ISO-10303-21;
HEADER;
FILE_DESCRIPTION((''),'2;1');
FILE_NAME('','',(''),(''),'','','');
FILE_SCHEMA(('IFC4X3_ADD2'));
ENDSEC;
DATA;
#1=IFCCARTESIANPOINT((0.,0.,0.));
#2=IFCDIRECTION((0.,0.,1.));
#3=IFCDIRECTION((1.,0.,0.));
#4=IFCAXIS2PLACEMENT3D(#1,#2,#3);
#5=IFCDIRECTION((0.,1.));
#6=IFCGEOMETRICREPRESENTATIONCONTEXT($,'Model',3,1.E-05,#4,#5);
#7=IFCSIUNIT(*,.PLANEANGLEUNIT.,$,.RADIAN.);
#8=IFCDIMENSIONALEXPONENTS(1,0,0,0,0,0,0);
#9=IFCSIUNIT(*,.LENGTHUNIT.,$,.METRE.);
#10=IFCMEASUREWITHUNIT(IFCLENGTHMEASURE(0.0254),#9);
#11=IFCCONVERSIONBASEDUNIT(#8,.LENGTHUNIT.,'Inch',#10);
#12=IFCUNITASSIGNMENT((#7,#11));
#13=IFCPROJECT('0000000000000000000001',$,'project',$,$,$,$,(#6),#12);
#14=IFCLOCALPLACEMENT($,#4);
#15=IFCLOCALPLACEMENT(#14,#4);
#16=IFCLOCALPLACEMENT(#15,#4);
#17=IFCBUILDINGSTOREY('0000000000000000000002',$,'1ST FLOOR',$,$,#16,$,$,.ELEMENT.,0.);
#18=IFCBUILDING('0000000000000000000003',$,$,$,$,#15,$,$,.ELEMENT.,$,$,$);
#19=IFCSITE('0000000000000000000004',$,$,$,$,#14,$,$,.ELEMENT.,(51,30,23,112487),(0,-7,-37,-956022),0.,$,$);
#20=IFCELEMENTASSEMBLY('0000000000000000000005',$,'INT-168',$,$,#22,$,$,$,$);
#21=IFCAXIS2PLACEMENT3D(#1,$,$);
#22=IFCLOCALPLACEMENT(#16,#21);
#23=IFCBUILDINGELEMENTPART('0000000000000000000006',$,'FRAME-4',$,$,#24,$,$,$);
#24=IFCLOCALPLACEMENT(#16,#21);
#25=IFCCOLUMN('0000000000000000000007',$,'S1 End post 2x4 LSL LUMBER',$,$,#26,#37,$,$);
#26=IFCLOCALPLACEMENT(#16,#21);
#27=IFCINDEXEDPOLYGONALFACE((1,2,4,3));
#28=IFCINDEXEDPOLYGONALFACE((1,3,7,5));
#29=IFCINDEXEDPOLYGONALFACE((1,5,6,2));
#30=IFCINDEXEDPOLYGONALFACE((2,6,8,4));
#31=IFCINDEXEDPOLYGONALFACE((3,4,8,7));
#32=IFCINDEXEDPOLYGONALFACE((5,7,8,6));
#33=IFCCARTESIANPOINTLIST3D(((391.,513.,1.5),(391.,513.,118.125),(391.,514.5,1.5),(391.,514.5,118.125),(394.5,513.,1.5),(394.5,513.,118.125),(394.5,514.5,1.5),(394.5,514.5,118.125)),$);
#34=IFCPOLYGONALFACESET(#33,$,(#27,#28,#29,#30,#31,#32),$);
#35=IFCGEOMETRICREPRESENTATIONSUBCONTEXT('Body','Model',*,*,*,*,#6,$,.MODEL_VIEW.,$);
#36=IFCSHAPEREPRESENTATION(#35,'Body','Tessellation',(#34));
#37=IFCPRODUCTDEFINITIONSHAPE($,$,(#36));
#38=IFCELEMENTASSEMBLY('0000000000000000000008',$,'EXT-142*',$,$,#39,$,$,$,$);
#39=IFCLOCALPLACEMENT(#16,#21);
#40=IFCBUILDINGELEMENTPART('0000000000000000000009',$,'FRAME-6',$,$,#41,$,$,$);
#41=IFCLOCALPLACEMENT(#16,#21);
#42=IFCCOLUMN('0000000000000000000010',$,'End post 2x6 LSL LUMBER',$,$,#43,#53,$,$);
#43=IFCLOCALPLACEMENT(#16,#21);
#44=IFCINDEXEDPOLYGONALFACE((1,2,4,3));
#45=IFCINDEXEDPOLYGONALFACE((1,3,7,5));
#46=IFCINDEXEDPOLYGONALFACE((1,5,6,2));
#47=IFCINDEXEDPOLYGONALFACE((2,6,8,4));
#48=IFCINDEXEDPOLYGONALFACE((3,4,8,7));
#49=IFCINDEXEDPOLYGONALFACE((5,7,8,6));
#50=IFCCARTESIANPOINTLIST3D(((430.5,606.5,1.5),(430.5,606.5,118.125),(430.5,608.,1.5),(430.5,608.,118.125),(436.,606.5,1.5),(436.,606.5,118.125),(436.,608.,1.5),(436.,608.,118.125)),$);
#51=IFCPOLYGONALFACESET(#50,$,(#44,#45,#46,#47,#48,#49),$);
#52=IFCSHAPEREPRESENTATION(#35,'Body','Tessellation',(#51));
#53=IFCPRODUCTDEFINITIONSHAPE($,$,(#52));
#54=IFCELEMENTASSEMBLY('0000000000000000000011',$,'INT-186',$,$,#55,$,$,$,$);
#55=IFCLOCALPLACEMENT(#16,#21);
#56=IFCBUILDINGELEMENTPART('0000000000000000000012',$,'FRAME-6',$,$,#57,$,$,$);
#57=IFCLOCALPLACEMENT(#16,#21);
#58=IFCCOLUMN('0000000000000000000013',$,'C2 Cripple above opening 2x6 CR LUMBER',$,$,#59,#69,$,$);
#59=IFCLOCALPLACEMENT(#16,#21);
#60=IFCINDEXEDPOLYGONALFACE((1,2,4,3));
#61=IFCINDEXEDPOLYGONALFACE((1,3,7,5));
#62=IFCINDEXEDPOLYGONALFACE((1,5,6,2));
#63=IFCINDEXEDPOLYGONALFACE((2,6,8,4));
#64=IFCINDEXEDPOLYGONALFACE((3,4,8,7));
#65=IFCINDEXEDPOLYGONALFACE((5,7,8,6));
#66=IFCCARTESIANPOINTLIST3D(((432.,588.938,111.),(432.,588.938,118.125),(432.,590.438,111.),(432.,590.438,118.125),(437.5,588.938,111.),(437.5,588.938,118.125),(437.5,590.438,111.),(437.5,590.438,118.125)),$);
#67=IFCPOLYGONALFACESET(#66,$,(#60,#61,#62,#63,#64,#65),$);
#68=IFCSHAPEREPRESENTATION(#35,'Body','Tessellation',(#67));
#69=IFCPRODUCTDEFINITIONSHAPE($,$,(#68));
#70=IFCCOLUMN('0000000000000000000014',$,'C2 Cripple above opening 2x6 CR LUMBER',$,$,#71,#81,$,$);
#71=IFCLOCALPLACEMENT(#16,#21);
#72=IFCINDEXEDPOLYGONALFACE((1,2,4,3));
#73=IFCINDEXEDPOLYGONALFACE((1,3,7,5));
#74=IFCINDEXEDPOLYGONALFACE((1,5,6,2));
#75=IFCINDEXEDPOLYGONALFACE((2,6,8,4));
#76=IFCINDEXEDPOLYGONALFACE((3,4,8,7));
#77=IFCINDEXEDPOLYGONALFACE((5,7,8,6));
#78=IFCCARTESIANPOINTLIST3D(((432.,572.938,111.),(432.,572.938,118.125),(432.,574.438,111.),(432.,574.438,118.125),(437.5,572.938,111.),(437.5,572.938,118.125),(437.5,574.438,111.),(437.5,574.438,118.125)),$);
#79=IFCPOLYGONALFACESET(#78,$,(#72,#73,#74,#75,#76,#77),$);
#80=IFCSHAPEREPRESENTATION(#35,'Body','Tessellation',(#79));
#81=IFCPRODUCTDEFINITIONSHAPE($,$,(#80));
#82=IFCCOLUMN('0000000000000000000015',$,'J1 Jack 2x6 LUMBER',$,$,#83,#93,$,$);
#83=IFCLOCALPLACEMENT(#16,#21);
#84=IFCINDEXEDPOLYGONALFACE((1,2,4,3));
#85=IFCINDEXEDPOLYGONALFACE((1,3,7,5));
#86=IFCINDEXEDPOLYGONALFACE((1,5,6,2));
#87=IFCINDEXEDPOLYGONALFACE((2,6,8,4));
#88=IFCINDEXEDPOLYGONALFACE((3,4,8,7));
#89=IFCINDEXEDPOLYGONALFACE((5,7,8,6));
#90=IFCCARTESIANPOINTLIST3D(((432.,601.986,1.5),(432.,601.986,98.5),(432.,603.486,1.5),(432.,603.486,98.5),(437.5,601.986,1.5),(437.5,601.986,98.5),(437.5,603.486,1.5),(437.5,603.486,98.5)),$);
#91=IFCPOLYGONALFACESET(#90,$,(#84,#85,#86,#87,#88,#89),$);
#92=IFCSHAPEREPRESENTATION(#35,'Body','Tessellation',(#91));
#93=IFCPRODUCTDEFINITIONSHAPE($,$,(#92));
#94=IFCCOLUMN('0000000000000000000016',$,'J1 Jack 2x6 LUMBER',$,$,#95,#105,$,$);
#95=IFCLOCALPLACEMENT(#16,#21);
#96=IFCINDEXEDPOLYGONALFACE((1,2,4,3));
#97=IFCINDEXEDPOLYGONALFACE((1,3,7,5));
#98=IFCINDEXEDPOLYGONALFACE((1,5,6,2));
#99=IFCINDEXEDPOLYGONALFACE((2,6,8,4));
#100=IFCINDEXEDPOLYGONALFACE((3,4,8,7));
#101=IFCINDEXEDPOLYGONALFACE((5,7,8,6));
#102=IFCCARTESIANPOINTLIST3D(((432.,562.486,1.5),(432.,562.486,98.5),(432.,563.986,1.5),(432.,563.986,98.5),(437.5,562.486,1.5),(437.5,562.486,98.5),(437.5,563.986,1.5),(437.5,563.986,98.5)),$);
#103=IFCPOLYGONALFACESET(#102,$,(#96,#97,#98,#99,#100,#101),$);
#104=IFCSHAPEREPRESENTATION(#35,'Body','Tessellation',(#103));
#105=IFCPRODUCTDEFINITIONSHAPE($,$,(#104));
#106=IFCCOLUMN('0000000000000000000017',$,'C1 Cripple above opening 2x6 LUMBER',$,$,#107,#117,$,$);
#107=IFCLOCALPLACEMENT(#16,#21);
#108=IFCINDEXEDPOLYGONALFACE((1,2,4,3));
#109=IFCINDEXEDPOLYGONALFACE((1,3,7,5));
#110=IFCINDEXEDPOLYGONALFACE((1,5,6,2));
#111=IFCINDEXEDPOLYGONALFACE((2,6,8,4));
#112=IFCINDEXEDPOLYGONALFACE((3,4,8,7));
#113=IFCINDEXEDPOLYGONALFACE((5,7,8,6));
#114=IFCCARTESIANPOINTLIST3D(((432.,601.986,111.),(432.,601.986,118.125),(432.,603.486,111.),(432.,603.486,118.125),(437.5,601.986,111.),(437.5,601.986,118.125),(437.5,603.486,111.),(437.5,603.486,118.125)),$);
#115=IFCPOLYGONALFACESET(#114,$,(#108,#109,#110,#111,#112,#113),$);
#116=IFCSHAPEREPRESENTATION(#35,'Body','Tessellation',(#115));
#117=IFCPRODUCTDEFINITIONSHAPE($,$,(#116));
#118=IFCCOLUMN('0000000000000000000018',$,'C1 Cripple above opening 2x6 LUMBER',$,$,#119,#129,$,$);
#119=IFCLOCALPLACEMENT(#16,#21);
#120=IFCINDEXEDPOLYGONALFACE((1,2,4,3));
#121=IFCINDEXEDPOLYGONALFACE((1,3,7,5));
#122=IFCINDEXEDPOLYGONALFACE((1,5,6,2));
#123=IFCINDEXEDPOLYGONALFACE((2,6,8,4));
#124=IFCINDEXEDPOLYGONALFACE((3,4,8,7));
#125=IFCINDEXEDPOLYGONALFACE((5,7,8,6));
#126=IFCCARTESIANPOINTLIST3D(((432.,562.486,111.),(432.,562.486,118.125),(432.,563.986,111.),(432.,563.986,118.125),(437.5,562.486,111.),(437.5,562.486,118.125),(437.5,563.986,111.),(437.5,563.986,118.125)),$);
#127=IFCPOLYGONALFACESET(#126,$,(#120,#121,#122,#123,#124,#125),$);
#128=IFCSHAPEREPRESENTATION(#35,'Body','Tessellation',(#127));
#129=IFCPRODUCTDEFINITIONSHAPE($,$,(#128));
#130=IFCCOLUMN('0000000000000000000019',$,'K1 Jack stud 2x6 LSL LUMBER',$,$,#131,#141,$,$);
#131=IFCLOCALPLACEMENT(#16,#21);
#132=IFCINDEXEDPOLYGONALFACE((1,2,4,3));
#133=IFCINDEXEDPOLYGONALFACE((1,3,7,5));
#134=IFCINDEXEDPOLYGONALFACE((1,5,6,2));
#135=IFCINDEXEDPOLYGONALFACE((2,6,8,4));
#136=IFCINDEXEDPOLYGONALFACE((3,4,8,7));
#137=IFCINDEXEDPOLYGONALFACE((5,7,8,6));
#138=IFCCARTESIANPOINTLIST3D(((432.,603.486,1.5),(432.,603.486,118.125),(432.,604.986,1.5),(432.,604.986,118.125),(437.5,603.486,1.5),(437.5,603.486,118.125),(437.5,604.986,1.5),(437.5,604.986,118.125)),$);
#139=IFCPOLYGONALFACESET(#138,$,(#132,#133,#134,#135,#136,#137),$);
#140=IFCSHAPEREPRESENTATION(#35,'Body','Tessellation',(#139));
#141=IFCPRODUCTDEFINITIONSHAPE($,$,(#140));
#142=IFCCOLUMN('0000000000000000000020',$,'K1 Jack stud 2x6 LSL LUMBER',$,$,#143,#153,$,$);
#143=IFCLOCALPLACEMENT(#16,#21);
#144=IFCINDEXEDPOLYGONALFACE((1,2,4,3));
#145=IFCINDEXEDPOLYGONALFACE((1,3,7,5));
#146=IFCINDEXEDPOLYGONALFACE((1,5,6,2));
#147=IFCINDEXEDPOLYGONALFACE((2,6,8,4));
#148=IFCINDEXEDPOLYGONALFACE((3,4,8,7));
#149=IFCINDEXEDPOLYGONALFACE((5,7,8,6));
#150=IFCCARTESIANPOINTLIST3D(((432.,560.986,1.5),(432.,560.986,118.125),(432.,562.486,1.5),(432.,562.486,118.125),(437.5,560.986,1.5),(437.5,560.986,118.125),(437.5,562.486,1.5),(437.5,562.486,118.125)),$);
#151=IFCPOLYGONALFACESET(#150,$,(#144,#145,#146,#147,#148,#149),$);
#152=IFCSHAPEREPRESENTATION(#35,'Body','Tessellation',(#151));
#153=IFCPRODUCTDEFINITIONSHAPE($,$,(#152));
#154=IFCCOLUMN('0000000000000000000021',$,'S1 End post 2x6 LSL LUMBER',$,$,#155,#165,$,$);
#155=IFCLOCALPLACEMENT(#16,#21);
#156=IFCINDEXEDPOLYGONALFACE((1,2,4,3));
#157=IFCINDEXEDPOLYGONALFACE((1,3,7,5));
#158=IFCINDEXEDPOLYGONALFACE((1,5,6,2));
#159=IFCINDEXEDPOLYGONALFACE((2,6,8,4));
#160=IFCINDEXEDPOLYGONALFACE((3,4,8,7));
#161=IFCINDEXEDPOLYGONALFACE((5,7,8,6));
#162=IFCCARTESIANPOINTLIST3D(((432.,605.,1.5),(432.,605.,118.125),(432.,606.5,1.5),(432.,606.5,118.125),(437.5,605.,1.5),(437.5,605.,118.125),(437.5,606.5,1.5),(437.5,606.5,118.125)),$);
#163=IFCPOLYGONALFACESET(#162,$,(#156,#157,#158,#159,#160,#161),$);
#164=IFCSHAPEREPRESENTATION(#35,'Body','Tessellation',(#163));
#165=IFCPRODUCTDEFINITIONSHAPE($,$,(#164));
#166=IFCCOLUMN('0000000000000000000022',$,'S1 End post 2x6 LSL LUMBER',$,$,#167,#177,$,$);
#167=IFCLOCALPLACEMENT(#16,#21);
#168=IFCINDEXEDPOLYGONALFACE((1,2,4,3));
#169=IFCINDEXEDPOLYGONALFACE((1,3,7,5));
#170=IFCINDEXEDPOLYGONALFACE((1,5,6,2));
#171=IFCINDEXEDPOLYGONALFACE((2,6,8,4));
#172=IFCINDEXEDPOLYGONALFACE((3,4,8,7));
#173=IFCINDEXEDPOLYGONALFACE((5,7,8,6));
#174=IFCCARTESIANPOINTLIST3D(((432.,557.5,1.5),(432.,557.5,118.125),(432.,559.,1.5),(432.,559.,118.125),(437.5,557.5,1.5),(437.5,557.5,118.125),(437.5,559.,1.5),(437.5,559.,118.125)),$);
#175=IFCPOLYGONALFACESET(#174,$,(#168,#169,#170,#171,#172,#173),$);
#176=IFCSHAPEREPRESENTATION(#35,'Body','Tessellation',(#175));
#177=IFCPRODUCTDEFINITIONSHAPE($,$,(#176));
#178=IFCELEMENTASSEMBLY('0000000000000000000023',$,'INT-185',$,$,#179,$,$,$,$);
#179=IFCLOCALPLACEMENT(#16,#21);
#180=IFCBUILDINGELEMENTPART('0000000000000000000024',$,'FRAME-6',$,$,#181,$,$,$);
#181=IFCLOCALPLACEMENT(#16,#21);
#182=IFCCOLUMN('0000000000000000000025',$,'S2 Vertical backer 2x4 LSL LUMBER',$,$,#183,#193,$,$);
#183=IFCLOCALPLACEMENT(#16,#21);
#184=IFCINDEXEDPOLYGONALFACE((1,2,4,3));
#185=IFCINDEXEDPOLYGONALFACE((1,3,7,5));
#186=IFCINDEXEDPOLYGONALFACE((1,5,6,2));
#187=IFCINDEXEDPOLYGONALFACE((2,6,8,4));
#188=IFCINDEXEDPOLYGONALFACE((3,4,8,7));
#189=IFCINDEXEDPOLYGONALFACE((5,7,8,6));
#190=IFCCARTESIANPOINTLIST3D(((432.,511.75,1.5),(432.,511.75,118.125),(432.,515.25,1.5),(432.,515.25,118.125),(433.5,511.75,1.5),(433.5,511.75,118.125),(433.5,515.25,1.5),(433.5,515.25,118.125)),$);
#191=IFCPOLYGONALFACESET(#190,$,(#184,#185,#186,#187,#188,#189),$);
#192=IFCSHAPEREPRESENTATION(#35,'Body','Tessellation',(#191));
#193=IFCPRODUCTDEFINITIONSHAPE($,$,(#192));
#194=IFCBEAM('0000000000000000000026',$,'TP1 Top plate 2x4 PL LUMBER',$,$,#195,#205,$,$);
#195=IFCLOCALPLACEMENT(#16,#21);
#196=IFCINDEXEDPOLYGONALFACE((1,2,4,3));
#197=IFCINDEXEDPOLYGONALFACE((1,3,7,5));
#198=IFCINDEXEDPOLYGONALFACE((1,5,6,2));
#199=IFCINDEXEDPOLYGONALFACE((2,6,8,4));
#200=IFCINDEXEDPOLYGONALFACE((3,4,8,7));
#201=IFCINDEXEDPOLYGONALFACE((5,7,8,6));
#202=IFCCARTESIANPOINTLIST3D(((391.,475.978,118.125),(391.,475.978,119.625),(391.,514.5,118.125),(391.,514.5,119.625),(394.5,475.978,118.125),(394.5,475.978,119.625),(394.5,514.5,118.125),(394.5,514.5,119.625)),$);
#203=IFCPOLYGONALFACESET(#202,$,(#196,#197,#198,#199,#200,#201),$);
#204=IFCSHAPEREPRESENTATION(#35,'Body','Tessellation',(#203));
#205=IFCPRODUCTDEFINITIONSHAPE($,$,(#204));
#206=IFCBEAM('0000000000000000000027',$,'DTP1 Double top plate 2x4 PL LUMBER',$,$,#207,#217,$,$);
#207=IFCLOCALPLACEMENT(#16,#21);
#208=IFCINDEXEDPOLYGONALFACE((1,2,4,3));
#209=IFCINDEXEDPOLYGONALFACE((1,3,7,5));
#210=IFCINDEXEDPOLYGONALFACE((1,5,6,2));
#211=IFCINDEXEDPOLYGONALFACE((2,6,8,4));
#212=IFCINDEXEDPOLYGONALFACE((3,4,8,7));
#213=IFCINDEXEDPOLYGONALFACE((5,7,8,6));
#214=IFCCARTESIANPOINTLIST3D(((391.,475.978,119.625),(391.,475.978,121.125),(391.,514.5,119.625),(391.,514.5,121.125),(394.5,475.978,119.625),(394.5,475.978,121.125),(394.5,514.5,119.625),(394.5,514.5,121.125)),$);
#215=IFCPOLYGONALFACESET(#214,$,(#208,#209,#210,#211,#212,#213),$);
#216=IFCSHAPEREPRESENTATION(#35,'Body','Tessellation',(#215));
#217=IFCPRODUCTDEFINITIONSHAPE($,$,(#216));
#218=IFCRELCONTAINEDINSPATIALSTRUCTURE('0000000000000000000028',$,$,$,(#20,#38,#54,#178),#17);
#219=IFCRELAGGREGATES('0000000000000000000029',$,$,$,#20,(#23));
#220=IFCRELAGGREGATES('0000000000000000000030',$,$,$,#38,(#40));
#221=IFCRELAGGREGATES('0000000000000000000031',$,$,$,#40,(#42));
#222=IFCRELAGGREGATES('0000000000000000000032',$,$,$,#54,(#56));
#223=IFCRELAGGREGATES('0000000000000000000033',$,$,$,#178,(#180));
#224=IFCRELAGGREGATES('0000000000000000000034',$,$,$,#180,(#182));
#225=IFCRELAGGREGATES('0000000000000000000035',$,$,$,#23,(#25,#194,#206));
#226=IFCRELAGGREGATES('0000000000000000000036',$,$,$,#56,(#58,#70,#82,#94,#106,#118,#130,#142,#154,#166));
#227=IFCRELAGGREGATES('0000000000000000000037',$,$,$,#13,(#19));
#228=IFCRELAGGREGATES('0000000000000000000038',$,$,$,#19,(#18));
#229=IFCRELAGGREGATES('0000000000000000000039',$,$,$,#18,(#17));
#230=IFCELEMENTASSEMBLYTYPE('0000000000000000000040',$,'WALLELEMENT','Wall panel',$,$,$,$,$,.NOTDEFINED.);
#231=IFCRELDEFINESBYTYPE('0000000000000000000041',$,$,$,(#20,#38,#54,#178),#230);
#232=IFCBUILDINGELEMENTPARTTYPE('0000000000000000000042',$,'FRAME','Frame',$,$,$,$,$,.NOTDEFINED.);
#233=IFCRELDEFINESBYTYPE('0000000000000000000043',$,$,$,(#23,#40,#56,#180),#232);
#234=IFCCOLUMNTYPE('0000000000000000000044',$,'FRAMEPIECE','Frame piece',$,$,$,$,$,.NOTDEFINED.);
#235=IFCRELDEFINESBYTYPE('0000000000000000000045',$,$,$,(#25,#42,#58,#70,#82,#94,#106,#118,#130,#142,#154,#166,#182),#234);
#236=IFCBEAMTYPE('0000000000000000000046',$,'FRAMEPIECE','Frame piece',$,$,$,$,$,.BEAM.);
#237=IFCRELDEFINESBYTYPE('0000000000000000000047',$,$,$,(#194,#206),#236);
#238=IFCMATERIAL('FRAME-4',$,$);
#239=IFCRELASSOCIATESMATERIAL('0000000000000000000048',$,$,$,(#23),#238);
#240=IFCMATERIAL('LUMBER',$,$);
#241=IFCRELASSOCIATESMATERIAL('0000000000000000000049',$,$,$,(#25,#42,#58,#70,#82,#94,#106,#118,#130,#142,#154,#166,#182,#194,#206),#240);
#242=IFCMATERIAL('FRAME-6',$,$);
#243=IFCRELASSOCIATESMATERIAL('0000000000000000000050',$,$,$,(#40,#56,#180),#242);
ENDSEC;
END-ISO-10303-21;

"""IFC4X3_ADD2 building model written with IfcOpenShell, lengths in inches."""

from ifc_helpers import new_model, entity, si_unit, converted_unit, direction, frame, origin_with_axes, origin_2d_with_axis, place, context, subcontext, project, spatial, rectangle, extrude, material, type_object, element, aggregate, save


model = new_model("IFC4X3_ADD2")

# Units and contexts
model_context = context("Model", 3, precision=1e-05, world=origin_with_axes(), true_north=direction((0.0, 1.0)))
body_context = subcontext(model_context, "Body", "Model", "MODEL_VIEW")
ifc_project = project(units=[si_unit("PLANEANGLEUNIT", "RADIAN"), converted_unit("LENGTHUNIT", "Inch", entity("IfcLengthMeasure", 0.0254), si_unit("LENGTHUNIT", "METRE"), dimensions=[1, 0, 0, 0, 0, 0, 0])], contexts=[model_context])

# Site, building, storey
site_placement = place(None, origin_with_axes())
site = spatial("IfcSite", under=ifc_project, at=site_placement, CompositionType="ELEMENT", RefLatitude=(51, 30, 23, 112487), RefLongitude=(0, -7, -37, -956022), RefElevation=0.0)
building_placement = place(site_placement, origin_with_axes())
building = spatial("IfcBuilding", under=site, at=building_placement, CompositionType="ELEMENT")
storey_placement = place(building_placement, origin_with_axes())
storey = spatial("IfcBuildingStorey", under=building, at=storey_placement, Name="1ST FLOOR", CompositionType="ELEMENT", Elevation=0.0)

# Element assemblies, building element parts, columns
element_assembly_type_1 = type_object("IfcElementAssemblyType", Name="WALLELEMENT", Description="Wall panel", PredefinedType="NOTDEFINED")
assembly_1_placement = place(storey_placement, origin_with_axes())
assembly_1 = element("IfcElementAssembly", 1, at=assembly_1_placement, inside=storey, type_object=element_assembly_type_1, Name="INT-168")
ifc_material_1 = material(Name="FRAME-4")
building_element_part_type = type_object("IfcBuildingElementPartType", Name="FRAME", Description="Frame", PredefinedType="NOTDEFINED")
building_element_part_1_placement = place(storey_placement, origin_with_axes())
building_element_part_1 = element("IfcBuildingElementPart", 2, at=building_element_part_1_placement, type_object=building_element_part_type, material=ifc_material_1, Name="FRAME-4")
aggregate(assembly_1, [building_element_part_1])
ifc_material_2 = material(Name="LUMBER")
column_type = type_object("IfcColumnType", Name="FRAMEPIECE", Description="Frame piece", PredefinedType="NOTDEFINED")
column_1_placement = place(storey_placement, frame((392.75, 513.75, 1.5), z_axis=(0.0, 0.0, 1.0), x_axis=(0.0, -1.0, 0.0)))
column_1 = element("IfcColumn", 3, at=column_1_placement, type_object=column_type, material=ifc_material_2, Name="S1 End post 2x4 LSL LUMBER", context=body_context, shape_type="SweptSolid", body=[
    extrude(rectangle(XDim=1.5, YDim=3.5, at=origin_2d_with_axis()), origin_with_axes(), (0.0, 0.0, 1.0), 116.625),
])
assembly_2_placement = place(storey_placement, origin_with_axes())
assembly_2 = element("IfcElementAssembly", 4, at=assembly_2_placement, inside=storey, type_object=element_assembly_type_1, Name="EXT-142*")
ifc_material_3 = material(Name="FRAME-6")
building_element_part_2_placement = place(storey_placement, origin_with_axes())
building_element_part_2 = element("IfcBuildingElementPart", 5, at=building_element_part_2_placement, type_object=building_element_part_type, material=ifc_material_3, Name="FRAME-6")
aggregate(assembly_2, [building_element_part_2])
column_2_placement = place(storey_placement, frame((433.25, 607.25, 118.125), z_axis=(0.0, 0.0, -1.0), x_axis=(0.0, -1.0, 0.0)))
column_2 = element("IfcColumn", 6, at=column_2_placement, type_object=column_type, material=ifc_material_2, Name="End post 2x6 LSL LUMBER", context=body_context, shape_type="SweptSolid", body=[
    extrude(rectangle(XDim=1.5, YDim=5.5, at=origin_2d_with_axis()), origin_with_axes(), (0.0, 0.0, 1.0), 116.625),
])
aggregate(building_element_part_2, [column_2])

# Element assembly, building element part, columns
assembly_3_placement = place(storey_placement, origin_with_axes())
assembly_3 = element("IfcElementAssembly", 7, at=assembly_3_placement, inside=storey, type_object=element_assembly_type_1, Name="INT-186")
building_element_part_3_placement = place(storey_placement, origin_with_axes())
building_element_part_3 = element("IfcBuildingElementPart", 8, at=building_element_part_3_placement, type_object=building_element_part_type, material=ifc_material_3, Name="FRAME-6")
aggregate(assembly_3, [building_element_part_3])
column_3_placement = place(storey_placement, frame((434.75, 589.688, 118.125), z_axis=(0.0, 0.0, -1.0), x_axis=(0.0, 1.0, 0.0)))
column_3 = element("IfcColumn", 9, at=column_3_placement, type_object=column_type, material=ifc_material_2, Name="C2 Cripple above opening 2x6 CR LUMBER", context=body_context, shape_type="SweptSolid", body=[
    extrude(rectangle(XDim=1.5, YDim=5.5, at=origin_2d_with_axis()), origin_with_axes(), (0.0, 0.0, 1.0), 7.125),
])
column_4_placement = place(storey_placement, frame((434.75, 573.688, 118.125), z_axis=(0.0, 0.0, -1.0), x_axis=(0.0, 1.0, 0.0)))
column_4 = element("IfcColumn", 10, at=column_4_placement, type_object=column_type, material=ifc_material_2, Name="C2 Cripple above opening 2x6 CR LUMBER", context=body_context, shape_type="SweptSolid", body=[
    extrude(rectangle(XDim=1.5, YDim=5.5, at=origin_2d_with_axis()), origin_with_axes(), (0.0, 0.0, 1.0), 7.125),
])
column_5_placement = place(storey_placement, frame((434.75, 602.736, 1.5), z_axis=(0.0, 0.0, 1.0), x_axis=(0.0, -1.0, 0.0)))
column_5 = element("IfcColumn", 11, at=column_5_placement, type_object=column_type, material=ifc_material_2, Name="J1 Jack 2x6 LUMBER", context=body_context, shape_type="SweptSolid", body=[
    extrude(rectangle(XDim=1.5, YDim=5.5, at=origin_2d_with_axis()), origin_with_axes(), (0.0, 0.0, 1.0), 97.0),
])
column_6_placement = place(storey_placement, frame((434.75, 563.236, 98.5), z_axis=(0.0, 0.0, -1.0), x_axis=(0.0, 1.0, 0.0)))
column_6 = element("IfcColumn", 12, at=column_6_placement, type_object=column_type, material=ifc_material_2, Name="J1 Jack 2x6 LUMBER", context=body_context, shape_type="SweptSolid", body=[
    extrude(rectangle(XDim=1.5, YDim=5.5, at=origin_2d_with_axis()), origin_with_axes(), (0.0, 0.0, 1.0), 97.0),
])
column_7_placement = place(storey_placement, frame((434.75, 602.736, 111.0), z_axis=(0.0, 0.0, 1.0), x_axis=(0.0, -1.0, 0.0)))
column_7 = element("IfcColumn", 13, at=column_7_placement, type_object=column_type, material=ifc_material_2, Name="C1 Cripple above opening 2x6 LUMBER", context=body_context, shape_type="SweptSolid", body=[
    extrude(rectangle(XDim=1.5, YDim=5.5, at=origin_2d_with_axis()), origin_with_axes(), (0.0, 0.0, 1.0), 7.125),
])
column_8_placement = place(storey_placement, frame((434.75, 563.236, 118.125), z_axis=(0.0, 0.0, -1.0), x_axis=(0.0, 1.0, 0.0)))
column_8 = element("IfcColumn", 14, at=column_8_placement, type_object=column_type, material=ifc_material_2, Name="C1 Cripple above opening 2x6 LUMBER", context=body_context, shape_type="SweptSolid", body=[
    extrude(rectangle(XDim=1.5, YDim=5.5, at=origin_2d_with_axis()), origin_with_axes(), (0.0, 0.0, 1.0), 7.125),
])
column_9_placement = place(storey_placement, frame((434.75, 604.236, 1.5), z_axis=(0.0, 0.0, 1.0), x_axis=(0.0, -1.0, 0.0)))
column_9 = element("IfcColumn", 15, at=column_9_placement, type_object=column_type, material=ifc_material_2, Name="K1 Jack stud 2x6 LSL LUMBER", context=body_context, shape_type="SweptSolid", body=[
    extrude(rectangle(XDim=1.5, YDim=5.5, at=origin_2d_with_axis()), origin_with_axes(), (0.0, 0.0, 1.0), 116.625),
])
column_10_placement = place(storey_placement, frame((434.75, 561.736, 118.125), z_axis=(0.0, 0.0, -1.0), x_axis=(0.0, 1.0, 0.0)))
column_10 = element("IfcColumn", 16, at=column_10_placement, type_object=column_type, material=ifc_material_2, Name="K1 Jack stud 2x6 LSL LUMBER", context=body_context, shape_type="SweptSolid", body=[
    extrude(rectangle(XDim=1.5, YDim=5.5, at=origin_2d_with_axis()), origin_with_axes(), (0.0, 0.0, 1.0), 116.625),
])
column_11_placement = place(storey_placement, frame((434.75, 605.75, 1.5), z_axis=(0.0, 0.0, 1.0), x_axis=(0.0, -1.0, 0.0)))
column_11 = element("IfcColumn", 17, at=column_11_placement, type_object=column_type, material=ifc_material_2, Name="S1 End post 2x6 LSL LUMBER", context=body_context, shape_type="SweptSolid", body=[
    extrude(rectangle(XDim=1.5, YDim=5.5, at=origin_2d_with_axis()), origin_with_axes(), (0.0, 0.0, 1.0), 116.625),
])
column_12_placement = place(storey_placement, frame((434.75, 558.25, 118.125), z_axis=(0.0, 0.0, -1.0), x_axis=(0.0, 1.0, 0.0)))
column_12 = element("IfcColumn", 18, at=column_12_placement, type_object=column_type, material=ifc_material_2, Name="S1 End post 2x6 LSL LUMBER", context=body_context, shape_type="SweptSolid", body=[
    extrude(rectangle(XDim=1.5, YDim=5.5, at=origin_2d_with_axis()), origin_with_axes(), (0.0, 0.0, 1.0), 116.625),
])

# Element assembly, building element part, column
assembly_4_placement = place(storey_placement, origin_with_axes())
assembly_4 = element("IfcElementAssembly", 19, at=assembly_4_placement, inside=storey, type_object=element_assembly_type_1, Name="INT-185")
building_element_part_4_placement = place(storey_placement, origin_with_axes())
building_element_part_4 = element("IfcBuildingElementPart", 20, at=building_element_part_4_placement, type_object=building_element_part_type, material=ifc_material_3, Name="FRAME-6")
aggregate(assembly_4, [building_element_part_4])
column_13_placement = place(storey_placement, frame((432.75, 513.5, 1.5), z_axis=(0.0, 0.0, 1.0), x_axis=(-1.0, 0.0, 0.0)))
column_13 = element("IfcColumn", 21, at=column_13_placement, type_object=column_type, material=ifc_material_2, Name="S2 Vertical backer 2x4 LSL LUMBER", context=body_context, shape_type="SweptSolid", body=[
    extrude(rectangle(XDim=1.5, YDim=3.5, at=origin_2d_with_axis()), origin_with_axes(), (0.0, 0.0, 1.0), 116.625),
])
aggregate(building_element_part_4, [column_13])

# Beams
beam_type_1 = type_object("IfcBeamType", Name="FRAMEPIECE", Description="Frame piece", PredefinedType="BEAM")
beam_1_placement = place(storey_placement, frame((392.75, 514.5, 118.875), z_axis=(0.0, -1.0, 0.0), x_axis=(0.0, 0.0, -1.0)))
beam_1 = element("IfcBeam", 22, at=beam_1_placement, type_object=beam_type_1, material=ifc_material_2, Name="TP1 Top plate 2x4 PL LUMBER", context=body_context, shape_type="SweptSolid", body=[
    extrude(rectangle(XDim=1.5, YDim=3.5, at=origin_2d_with_axis()), origin_with_axes(), (0.0, 0.0, 1.0), 38.522),
])
beam_2_placement = place(storey_placement, frame((392.75, 514.5, 120.375), z_axis=(0.0, -1.0, 0.0), x_axis=(0.0, 0.0, -1.0)))
beam_2 = element("IfcBeam", 23, at=beam_2_placement, type_object=beam_type_1, material=ifc_material_2, Name="DTP1 Double top plate 2x4 PL LUMBER", context=body_context, shape_type="SweptSolid", body=[
    extrude(rectangle(XDim=1.5, YDim=3.5, at=origin_2d_with_axis()), origin_with_axes(), (0.0, 0.0, 1.0), 38.522),
])
aggregate(building_element_part_1, [column_1, beam_1, beam_2])
aggregate(building_element_part_3, [column_3, column_4, column_5, column_6, column_7, column_8, column_9, column_10, column_11, column_12])

save(model, "model.ifc")
